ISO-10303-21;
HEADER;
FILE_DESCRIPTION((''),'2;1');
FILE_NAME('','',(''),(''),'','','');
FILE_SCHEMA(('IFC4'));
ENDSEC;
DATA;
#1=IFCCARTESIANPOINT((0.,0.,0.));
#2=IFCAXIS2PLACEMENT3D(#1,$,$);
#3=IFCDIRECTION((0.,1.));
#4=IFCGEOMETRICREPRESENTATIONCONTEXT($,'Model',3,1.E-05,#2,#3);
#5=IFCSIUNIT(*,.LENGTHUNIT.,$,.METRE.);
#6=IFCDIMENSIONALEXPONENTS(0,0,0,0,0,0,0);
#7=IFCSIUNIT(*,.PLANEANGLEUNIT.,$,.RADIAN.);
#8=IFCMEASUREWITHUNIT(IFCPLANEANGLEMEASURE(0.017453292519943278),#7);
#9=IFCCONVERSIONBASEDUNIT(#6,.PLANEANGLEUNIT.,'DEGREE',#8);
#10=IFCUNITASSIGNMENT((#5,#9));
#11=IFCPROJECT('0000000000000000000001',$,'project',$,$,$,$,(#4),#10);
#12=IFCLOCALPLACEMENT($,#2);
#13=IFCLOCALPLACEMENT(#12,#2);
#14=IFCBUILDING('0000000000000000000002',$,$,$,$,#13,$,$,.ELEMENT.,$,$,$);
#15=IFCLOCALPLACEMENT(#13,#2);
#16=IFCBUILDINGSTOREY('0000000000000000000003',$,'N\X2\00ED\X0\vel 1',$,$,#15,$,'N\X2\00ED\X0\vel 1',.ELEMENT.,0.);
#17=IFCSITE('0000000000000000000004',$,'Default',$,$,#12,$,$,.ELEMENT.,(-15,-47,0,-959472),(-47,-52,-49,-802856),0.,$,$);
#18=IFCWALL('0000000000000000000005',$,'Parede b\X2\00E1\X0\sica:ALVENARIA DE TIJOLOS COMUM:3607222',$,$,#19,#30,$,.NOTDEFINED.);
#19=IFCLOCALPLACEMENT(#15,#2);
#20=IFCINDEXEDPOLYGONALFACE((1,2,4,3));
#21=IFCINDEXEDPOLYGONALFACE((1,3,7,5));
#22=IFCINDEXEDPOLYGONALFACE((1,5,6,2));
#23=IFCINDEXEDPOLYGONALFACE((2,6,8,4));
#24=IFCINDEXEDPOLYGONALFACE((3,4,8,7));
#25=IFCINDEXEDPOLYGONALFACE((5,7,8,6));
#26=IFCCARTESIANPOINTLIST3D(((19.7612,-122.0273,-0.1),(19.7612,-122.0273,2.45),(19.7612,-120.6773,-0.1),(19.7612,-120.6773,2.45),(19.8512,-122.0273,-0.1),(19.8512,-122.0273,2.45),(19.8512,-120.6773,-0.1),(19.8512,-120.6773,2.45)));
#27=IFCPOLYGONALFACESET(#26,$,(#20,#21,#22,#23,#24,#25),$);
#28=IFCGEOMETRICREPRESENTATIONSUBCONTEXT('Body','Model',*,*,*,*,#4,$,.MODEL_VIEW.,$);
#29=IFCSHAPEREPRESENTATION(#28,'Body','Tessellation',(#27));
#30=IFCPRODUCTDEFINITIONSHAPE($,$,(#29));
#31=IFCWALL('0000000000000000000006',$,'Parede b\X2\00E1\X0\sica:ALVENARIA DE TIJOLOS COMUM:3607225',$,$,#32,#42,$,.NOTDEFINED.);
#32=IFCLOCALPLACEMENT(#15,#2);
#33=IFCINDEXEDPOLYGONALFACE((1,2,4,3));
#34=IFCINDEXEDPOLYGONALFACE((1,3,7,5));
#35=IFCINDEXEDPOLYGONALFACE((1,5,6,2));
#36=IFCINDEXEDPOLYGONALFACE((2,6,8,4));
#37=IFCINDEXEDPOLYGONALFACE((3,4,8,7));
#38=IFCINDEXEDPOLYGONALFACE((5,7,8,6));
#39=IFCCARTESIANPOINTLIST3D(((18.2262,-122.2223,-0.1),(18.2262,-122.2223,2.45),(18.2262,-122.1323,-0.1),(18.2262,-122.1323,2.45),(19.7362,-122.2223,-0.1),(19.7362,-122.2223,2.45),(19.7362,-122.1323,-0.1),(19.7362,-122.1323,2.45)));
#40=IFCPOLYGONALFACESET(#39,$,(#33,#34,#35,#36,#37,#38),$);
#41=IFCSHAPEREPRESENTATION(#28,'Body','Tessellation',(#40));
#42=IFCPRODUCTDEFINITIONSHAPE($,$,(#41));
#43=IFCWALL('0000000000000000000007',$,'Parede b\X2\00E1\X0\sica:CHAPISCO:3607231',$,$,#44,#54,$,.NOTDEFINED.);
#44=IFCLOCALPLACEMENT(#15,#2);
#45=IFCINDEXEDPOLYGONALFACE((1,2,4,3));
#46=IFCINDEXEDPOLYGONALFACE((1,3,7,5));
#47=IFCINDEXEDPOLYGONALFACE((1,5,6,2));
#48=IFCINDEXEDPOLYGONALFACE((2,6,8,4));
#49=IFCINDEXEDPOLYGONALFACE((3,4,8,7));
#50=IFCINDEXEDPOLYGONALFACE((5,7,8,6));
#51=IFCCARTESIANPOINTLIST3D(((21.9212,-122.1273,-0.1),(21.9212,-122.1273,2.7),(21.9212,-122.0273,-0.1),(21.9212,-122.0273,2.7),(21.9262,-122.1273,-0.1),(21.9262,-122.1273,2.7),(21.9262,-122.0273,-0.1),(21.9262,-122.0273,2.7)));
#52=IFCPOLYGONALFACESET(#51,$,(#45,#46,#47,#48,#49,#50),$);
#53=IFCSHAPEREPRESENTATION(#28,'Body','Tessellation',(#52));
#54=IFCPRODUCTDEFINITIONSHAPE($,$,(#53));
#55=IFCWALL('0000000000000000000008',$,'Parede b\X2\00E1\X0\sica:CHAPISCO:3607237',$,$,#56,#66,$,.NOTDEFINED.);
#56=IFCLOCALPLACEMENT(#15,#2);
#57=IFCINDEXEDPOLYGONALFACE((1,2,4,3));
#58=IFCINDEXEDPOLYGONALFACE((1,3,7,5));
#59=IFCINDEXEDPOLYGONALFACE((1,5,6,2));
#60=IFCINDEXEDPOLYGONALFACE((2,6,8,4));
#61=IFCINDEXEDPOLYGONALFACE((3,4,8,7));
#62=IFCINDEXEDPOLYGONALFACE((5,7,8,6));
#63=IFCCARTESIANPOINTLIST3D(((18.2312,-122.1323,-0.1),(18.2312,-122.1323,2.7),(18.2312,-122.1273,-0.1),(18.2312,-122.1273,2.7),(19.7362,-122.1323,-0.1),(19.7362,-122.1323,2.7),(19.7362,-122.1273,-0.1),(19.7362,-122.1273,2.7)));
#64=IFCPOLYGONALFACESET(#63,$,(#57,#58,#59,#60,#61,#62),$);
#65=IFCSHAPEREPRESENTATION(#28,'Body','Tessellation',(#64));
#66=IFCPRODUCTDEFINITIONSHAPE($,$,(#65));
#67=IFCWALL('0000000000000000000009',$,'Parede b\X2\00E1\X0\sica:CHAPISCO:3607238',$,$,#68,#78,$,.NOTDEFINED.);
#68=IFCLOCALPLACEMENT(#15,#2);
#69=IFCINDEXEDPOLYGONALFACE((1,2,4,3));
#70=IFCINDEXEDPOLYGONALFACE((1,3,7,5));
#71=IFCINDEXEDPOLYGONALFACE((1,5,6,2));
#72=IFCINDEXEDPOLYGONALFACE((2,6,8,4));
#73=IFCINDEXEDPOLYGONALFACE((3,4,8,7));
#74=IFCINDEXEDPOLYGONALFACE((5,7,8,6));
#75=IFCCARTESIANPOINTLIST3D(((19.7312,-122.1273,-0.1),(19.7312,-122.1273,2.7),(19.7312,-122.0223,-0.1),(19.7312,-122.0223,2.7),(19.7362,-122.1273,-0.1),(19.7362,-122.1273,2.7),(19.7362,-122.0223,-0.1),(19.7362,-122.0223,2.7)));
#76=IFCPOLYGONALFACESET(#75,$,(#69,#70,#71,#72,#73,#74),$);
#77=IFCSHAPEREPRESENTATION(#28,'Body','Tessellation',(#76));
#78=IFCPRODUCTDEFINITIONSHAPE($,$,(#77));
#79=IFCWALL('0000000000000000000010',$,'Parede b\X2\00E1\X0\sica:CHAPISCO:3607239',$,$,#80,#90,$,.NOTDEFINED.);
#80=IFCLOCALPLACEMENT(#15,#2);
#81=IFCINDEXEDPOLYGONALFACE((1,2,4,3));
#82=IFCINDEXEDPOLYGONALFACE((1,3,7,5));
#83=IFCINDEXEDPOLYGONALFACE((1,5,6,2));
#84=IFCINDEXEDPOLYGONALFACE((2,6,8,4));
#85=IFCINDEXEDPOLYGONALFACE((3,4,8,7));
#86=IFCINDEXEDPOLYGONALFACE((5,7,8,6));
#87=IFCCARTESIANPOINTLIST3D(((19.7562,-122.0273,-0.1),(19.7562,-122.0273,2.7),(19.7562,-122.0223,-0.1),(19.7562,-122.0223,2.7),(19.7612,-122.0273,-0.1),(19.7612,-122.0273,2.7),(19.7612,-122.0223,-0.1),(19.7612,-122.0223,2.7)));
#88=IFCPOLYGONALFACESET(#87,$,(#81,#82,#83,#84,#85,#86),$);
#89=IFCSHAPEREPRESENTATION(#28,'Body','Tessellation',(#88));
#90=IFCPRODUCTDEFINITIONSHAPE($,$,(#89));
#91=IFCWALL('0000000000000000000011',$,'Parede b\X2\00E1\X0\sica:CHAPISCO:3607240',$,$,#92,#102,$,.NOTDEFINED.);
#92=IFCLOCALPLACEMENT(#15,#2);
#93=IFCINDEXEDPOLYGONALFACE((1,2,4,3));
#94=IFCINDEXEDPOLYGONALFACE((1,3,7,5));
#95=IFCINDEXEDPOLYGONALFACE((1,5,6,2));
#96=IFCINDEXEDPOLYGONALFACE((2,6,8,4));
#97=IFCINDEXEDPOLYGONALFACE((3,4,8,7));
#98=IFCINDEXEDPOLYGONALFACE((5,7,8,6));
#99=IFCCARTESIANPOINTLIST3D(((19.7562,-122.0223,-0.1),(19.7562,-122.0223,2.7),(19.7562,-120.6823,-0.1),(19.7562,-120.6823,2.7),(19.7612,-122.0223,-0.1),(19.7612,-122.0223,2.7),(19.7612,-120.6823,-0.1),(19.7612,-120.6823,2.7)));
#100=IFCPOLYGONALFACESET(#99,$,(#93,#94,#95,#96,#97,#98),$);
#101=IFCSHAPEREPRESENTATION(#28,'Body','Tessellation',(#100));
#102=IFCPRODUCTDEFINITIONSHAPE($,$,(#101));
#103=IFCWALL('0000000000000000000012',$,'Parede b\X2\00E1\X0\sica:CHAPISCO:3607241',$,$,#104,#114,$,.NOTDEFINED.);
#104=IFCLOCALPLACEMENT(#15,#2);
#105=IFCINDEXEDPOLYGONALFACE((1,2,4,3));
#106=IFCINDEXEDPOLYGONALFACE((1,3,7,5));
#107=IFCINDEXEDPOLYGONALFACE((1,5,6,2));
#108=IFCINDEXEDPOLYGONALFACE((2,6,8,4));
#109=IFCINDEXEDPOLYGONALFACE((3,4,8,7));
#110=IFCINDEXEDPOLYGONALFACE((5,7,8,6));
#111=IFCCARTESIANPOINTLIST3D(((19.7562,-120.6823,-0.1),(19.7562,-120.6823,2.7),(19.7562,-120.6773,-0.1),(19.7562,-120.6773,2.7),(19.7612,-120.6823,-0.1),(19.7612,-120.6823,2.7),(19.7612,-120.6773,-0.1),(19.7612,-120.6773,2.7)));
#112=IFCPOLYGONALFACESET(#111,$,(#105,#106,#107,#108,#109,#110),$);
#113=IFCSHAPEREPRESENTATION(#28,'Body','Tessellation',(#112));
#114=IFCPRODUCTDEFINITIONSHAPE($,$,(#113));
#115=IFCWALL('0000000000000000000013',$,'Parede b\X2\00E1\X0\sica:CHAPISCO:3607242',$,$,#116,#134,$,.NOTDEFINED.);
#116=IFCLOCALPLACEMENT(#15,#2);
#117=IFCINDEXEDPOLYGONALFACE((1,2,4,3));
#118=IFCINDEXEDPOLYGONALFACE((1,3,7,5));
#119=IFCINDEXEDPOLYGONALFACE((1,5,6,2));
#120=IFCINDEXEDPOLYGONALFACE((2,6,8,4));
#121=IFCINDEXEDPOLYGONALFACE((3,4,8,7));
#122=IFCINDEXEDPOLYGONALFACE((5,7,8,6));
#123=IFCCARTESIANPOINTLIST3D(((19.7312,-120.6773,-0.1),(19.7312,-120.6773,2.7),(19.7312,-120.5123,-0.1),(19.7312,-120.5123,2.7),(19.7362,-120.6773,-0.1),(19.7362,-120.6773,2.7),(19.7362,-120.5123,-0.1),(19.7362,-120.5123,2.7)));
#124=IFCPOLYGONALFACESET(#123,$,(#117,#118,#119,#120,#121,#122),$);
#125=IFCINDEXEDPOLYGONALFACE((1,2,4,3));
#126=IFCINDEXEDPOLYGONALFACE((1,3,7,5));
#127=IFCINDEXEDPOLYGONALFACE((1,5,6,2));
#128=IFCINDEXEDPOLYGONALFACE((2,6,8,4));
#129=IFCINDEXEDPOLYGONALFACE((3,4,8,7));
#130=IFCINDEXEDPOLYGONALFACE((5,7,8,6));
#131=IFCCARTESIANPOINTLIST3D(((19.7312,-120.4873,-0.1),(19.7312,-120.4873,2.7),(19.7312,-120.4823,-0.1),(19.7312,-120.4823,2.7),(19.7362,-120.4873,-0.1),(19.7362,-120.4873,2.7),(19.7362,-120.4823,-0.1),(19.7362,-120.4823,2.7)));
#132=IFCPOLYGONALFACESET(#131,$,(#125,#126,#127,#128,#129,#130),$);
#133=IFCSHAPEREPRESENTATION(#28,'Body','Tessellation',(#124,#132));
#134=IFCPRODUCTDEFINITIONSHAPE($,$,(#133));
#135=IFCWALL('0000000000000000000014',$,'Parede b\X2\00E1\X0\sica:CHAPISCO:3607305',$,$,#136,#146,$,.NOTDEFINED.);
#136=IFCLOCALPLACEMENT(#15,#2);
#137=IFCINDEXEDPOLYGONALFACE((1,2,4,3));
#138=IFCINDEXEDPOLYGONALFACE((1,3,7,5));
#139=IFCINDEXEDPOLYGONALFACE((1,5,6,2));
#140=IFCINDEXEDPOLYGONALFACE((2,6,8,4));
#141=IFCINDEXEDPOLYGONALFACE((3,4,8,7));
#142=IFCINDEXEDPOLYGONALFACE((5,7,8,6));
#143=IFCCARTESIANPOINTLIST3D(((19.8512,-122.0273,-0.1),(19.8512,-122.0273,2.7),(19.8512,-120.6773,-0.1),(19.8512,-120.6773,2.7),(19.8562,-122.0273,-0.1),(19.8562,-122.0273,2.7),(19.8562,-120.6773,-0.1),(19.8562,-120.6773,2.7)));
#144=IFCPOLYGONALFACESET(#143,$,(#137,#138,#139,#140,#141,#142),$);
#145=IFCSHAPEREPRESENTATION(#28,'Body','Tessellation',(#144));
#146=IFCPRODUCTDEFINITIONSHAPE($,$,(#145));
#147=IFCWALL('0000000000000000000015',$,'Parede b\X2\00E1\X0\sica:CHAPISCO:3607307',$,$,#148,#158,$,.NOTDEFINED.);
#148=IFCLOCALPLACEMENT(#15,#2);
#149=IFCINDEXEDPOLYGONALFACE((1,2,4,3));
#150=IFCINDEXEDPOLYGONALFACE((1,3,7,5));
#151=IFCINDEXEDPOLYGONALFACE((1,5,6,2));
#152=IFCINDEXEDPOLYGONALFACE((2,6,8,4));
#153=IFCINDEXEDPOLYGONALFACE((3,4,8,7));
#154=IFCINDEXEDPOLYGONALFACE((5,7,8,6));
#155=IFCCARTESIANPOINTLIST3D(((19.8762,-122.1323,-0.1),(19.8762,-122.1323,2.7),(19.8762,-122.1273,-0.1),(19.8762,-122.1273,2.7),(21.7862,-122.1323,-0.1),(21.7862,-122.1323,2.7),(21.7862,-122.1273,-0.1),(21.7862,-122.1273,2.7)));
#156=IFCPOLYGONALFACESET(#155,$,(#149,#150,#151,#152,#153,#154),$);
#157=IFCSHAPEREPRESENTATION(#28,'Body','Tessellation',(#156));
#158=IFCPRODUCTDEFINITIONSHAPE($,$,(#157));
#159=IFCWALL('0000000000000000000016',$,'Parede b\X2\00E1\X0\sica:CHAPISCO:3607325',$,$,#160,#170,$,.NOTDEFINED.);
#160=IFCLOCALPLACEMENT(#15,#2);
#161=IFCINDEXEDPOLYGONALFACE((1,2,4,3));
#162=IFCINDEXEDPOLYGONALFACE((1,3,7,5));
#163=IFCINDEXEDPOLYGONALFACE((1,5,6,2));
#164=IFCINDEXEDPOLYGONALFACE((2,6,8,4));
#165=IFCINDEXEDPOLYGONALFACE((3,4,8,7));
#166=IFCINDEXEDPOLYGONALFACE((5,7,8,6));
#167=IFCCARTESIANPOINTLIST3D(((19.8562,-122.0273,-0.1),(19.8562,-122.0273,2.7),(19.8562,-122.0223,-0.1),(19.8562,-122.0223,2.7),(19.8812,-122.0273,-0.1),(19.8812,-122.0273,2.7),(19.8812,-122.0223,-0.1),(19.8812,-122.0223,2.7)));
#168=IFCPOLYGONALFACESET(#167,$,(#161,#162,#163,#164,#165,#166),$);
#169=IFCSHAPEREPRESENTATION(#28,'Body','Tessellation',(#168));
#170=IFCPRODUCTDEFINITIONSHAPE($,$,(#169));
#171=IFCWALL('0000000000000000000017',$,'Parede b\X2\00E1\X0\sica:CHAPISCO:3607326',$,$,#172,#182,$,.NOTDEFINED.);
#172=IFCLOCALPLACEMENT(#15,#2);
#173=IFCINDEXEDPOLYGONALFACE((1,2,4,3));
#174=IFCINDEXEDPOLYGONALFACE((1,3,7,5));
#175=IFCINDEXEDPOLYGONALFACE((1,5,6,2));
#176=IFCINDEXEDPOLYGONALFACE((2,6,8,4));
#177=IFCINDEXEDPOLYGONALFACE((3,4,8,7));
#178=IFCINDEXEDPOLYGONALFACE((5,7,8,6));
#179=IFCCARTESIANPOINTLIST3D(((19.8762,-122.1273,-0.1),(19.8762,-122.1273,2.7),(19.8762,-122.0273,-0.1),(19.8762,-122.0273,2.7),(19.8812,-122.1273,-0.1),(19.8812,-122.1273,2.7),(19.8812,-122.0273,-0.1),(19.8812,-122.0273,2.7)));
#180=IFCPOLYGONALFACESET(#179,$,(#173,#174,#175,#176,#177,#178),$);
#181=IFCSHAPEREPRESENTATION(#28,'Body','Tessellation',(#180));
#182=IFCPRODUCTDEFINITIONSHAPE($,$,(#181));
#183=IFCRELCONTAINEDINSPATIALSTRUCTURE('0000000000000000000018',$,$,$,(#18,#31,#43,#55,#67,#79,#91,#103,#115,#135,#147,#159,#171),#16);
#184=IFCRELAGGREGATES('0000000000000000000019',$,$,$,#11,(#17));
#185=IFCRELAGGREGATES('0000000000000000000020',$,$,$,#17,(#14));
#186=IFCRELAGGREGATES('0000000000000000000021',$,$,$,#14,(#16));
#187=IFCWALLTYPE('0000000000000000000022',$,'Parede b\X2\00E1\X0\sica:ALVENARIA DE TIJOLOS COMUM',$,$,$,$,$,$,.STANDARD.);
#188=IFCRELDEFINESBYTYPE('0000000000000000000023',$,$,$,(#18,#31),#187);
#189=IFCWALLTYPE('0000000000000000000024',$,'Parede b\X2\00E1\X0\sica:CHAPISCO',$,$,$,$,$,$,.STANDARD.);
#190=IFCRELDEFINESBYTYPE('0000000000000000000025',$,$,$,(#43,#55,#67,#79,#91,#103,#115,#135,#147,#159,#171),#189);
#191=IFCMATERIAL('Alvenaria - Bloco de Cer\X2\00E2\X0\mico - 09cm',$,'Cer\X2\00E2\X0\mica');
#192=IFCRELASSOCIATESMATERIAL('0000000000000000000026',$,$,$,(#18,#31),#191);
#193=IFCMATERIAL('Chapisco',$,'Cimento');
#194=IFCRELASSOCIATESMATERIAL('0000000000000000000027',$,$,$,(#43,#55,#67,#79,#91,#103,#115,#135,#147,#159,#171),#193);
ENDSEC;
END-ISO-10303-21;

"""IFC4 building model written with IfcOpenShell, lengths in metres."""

from ifc_helpers import new_model, entity, si_unit, converted_unit, direction, frame, origin, place, context, subcontext, project, spatial, indexed_curve, outline, extrude, material, type_object, element, save


model = new_model("IFC4")

# Units and contexts
model_context = context("Model", 3, precision=1e-05, world=origin(), true_north=direction((0.0, 1.0)))
body_context = subcontext(model_context, "Body", "Model", "MODEL_VIEW")
ifc_project = project(units=[si_unit("LENGTHUNIT", "METRE"), converted_unit("PLANEANGLEUNIT", "DEGREE", entity("IfcPlaneAngleMeasure", 0.017453292519943278), si_unit("PLANEANGLEUNIT", "RADIAN"), dimensions=[0, 0, 0, 0, 0, 0, 0])], contexts=[model_context])

# Site, building, storey
site_placement = place(None, origin())
site = spatial("IfcSite", under=ifc_project, at=site_placement, Name="Default", CompositionType="ELEMENT", RefLatitude=(-15, -47, 0, -959472), RefLongitude=(-47, -52, -49, -802856), RefElevation=0.0)
building_placement = place(site_placement, origin())
building = spatial("IfcBuilding", under=site, at=building_placement, CompositionType="ELEMENT")
storey_placement = place(building_placement, origin())
storey = spatial("IfcBuildingStorey", under=building, at=storey_placement, Name="Nível 1", LongName="Nível 1", CompositionType="ELEMENT", Elevation=0.0)

# Walls
ifc_material_1 = material(Name="Alvenaria - Bloco de Cerâmico - 09cm", Category="Cerâmica")
wall_type_1 = type_object("IfcWallType", Name="Parede básica:ALVENARIA DE TIJOLOS COMUM", PredefinedType="STANDARD")
wall_1_placement = place(storey_placement, frame((19.8062, -122.0273, -0.1), z_axis=(0.0, 0.0, 1.0), x_axis=(0.0, 1.0, 0.0)))
element("IfcWall", 1, at=wall_1_placement, inside=storey, type_object=wall_type_1, material=ifc_material_1, Name="Parede básica:ALVENARIA DE TIJOLOS COMUM:3607222", PredefinedType="NOTDEFINED", context=body_context, shape_type="SweptSolid", body=[
    extrude(outline(indexed_curve([(1.35, 0.045), (0.0, 0.045), (0.0, -0.045), (1.35, -0.045), (1.35, 0.045)], self_intersect=False)), origin(), (0.0, 0.0, 1.0), 2.55),
])
wall_2_placement = place(storey_placement, frame((19.7362, -122.1773, -0.1), z_axis=(0.0, 0.0, 1.0), x_axis=(-1.0, 0.0, 0.0)))
element("IfcWall", 2, at=wall_2_placement, inside=storey, type_object=wall_type_1, material=ifc_material_1, Name="Parede básica:ALVENARIA DE TIJOLOS COMUM:3607225", PredefinedType="NOTDEFINED", context=body_context, shape_type="SweptSolid", body=[
    extrude(outline(indexed_curve([(1.51, 0.045), (0.0, 0.045), (0.0, -0.045), (1.51, -0.045), (1.51, 0.045)], self_intersect=False)), origin(), (0.0, 0.0, 1.0), 2.55),
])
ifc_material_2 = material(Name="Chapisco", Category="Cimento")
wall_type_2 = type_object("IfcWallType", Name="Parede básica:CHAPISCO", PredefinedType="STANDARD")
wall_3_placement = place(storey_placement, frame((21.9237, -122.0273, -0.1), z_axis=(0.0, 0.0, 1.0), x_axis=(0.0, -1.0, 0.0)))
element("IfcWall", 3, at=wall_3_placement, inside=storey, type_object=wall_type_2, material=ifc_material_2, Name="Parede básica:CHAPISCO:3607231", PredefinedType="NOTDEFINED", context=body_context, shape_type="SweptSolid", body=[
    extrude(outline(indexed_curve([(0.1, 0.0025), (0.0, 0.0025), (0.0, -0.0025), (0.1, -0.0025), (0.1, 0.0025)], self_intersect=False)), origin(), (0.0, 0.0, 1.0), 2.8),
])
wall_4_placement = place(storey_placement, frame((19.7362, -122.1298, -0.1), z_axis=(0.0, 0.0, 1.0), x_axis=(-1.0, 0.0, 0.0)))
element("IfcWall", 4, at=wall_4_placement, inside=storey, type_object=wall_type_2, material=ifc_material_2, Name="Parede básica:CHAPISCO:3607237", PredefinedType="NOTDEFINED", context=body_context, shape_type="SweptSolid", body=[
    extrude(outline(indexed_curve([(1.505, 0.0025), (0.0, 0.0025), (0.0, -0.0025), (1.505, -0.0025), (1.505, 0.0025)], self_intersect=False)), origin(), (0.0, 0.0, 1.0), 2.8),
])
wall_5_placement = place(storey_placement, frame((19.7337, -122.0223, -0.1), z_axis=(0.0, 0.0, 1.0), x_axis=(0.0, -1.0, 0.0)))
element("IfcWall", 5, at=wall_5_placement, inside=storey, type_object=wall_type_2, material=ifc_material_2, Name="Parede básica:CHAPISCO:3607238", PredefinedType="NOTDEFINED", context=body_context, shape_type="SweptSolid", body=[
    extrude(outline(indexed_curve([(0.105, 0.0025), (0.0, 0.0025), (0.0, -0.0025), (0.105, -0.0025), (0.105, 0.0025)], self_intersect=False)), origin(), (0.0, 0.0, 1.0), 2.8),
])
wall_6_placement = place(storey_placement, frame((19.7612, -122.0248, -0.1), z_axis=(0.0, 0.0, 1.0), x_axis=(-1.0, 0.0, 0.0)))
element("IfcWall", 6, at=wall_6_placement, inside=storey, type_object=wall_type_2, material=ifc_material_2, Name="Parede básica:CHAPISCO:3607239", PredefinedType="NOTDEFINED", context=body_context, shape_type="SweptSolid", body=[
    extrude(outline(indexed_curve([(0.005, 0.0025), (0.0, 0.0025), (0.0, -0.0025), (0.005, -0.0025), (0.005, 0.0025)], self_intersect=False)), origin(), (0.0, 0.0, 1.0), 2.8),
])
wall_7_placement = place(storey_placement, frame((19.7587, -120.6823, -0.1), z_axis=(0.0, 0.0, 1.0), x_axis=(0.0, -1.0, 0.0)))
element("IfcWall", 7, at=wall_7_placement, inside=storey, type_object=wall_type_2, material=ifc_material_2, Name="Parede básica:CHAPISCO:3607240", PredefinedType="NOTDEFINED", context=body_context, shape_type="SweptSolid", body=[
    extrude(outline(indexed_curve([(1.34, 0.0025), (0.0, 0.0025), (0.0, -0.0025), (1.34, -0.0025), (1.34, 0.0025)], self_intersect=False)), origin(), (0.0, 0.0, 1.0), 2.8),
])
wall_8_placement = place(storey_placement, frame((19.7562, -120.6798, -0.1)))
element("IfcWall", 8, at=wall_8_placement, inside=storey, type_object=wall_type_2, material=ifc_material_2, Name="Parede básica:CHAPISCO:3607241", PredefinedType="NOTDEFINED", context=body_context, shape_type="SweptSolid", body=[
    extrude(outline(indexed_curve([(0.005, 0.0025), (0.0, 0.0025), (0.0, -0.0025), (0.005, -0.0025), (0.005, 0.0025)], self_intersect=False)), origin(), (0.0, 0.0, 1.0), 2.8),
])
wall_9_placement = place(storey_placement, frame((19.7337, -120.4823, -0.1), z_axis=(0.0, 0.0, 1.0), x_axis=(0.0, -1.0, 0.0)))
element("IfcWall", 9, at=wall_9_placement, inside=storey, type_object=wall_type_2, material=ifc_material_2, Name="Parede básica:CHAPISCO:3607242", PredefinedType="NOTDEFINED", context=body_context, shape_type="SweptSolid", body=[
    extrude(outline(indexed_curve([(-0.0025, -0.0825), (0.0025, -0.0825), (0.0025, 0.0825), (-0.0025, 0.0825), (-0.0025, -0.0825)], self_intersect=False)), frame((0.1125, 0.0, 0.0), z_axis=(0.0, 0.0, 1.0), x_axis=(0.0, 1.0, 0.0)), (0.0, 0.0, 1.0), 2.8),
    extrude(outline(indexed_curve([(-0.0025, -0.0025), (0.0025, -0.0025), (0.0025, 0.0025), (-0.0025, 0.0025), (-0.0025, -0.0025)], self_intersect=False)), frame((0.0025, 0.0, 0.0), z_axis=(0.0, 0.0, 1.0), x_axis=(0.0, 1.0, 0.0)), (0.0, 0.0, 1.0), 2.8),
])
wall_10_placement = place(storey_placement, frame((19.8537, -122.0273, -0.1), z_axis=(0.0, 0.0, 1.0), x_axis=(0.0, 1.0, 0.0)))
element("IfcWall", 10, at=wall_10_placement, inside=storey, type_object=wall_type_2, material=ifc_material_2, Name="Parede básica:CHAPISCO:3607305", PredefinedType="NOTDEFINED", context=body_context, shape_type="SweptSolid", body=[
    extrude(outline(indexed_curve([(1.35, 0.0025), (0.0, 0.0025), (0.0, -0.0025), (1.35, -0.0025), (1.35, 0.0025)], self_intersect=False)), origin(), (0.0, 0.0, 1.0), 2.8),
])
wall_11_placement = place(storey_placement, frame((21.7862, -122.1298, -0.1), z_axis=(0.0, 0.0, 1.0), x_axis=(-1.0, 0.0, 0.0)))
element("IfcWall", 11, at=wall_11_placement, inside=storey, type_object=wall_type_2, material=ifc_material_2, Name="Parede básica:CHAPISCO:3607307", PredefinedType="NOTDEFINED", context=body_context, shape_type="SweptSolid", body=[
    extrude(outline(indexed_curve([(1.91, 0.0025), (0.0, 0.0025), (0.0, -0.0025), (1.91, -0.0025), (1.91, 0.0025)], self_intersect=False)), origin(), (0.0, 0.0, 1.0), 2.8),
])
wall_12_placement = place(storey_placement, frame((19.8562, -122.0248, -0.1)))
element("IfcWall", 12, at=wall_12_placement, inside=storey, type_object=wall_type_2, material=ifc_material_2, Name="Parede básica:CHAPISCO:3607325", PredefinedType="NOTDEFINED", context=body_context, shape_type="SweptSolid", body=[
    extrude(outline(indexed_curve([(0.025, 0.0025), (0.0, 0.0025), (0.0, -0.0025), (0.025, -0.0025), (0.025, 0.0025)], self_intersect=False)), origin(), (0.0, 0.0, 1.0), 2.8),
])
for number, where, z_axis, x_axis, name in (
    (13, (19.8787, -122.0273, -0.1), (0.0, 0.0, 1.0), (0.0, -1.0, 0.0), "Parede básica:CHAPISCO:3607326"),
):
    element("IfcWall", number, at=place(storey_placement, frame(where, z_axis=z_axis, x_axis=x_axis)), inside=storey, type_object=wall_type_2, material=ifc_material_2, Name=name, PredefinedType="NOTDEFINED", context=body_context, shape_type="SweptSolid", body=[
        extrude(outline(indexed_curve([(0.1, 0.0025), (0.0, 0.0025), (0.0, -0.0025), (0.1, -0.0025), (0.1, 0.0025)], self_intersect=False)), origin(), (0.0, 0.0, 1.0), 2.8),
    ])

save(model, "model.ifc")
